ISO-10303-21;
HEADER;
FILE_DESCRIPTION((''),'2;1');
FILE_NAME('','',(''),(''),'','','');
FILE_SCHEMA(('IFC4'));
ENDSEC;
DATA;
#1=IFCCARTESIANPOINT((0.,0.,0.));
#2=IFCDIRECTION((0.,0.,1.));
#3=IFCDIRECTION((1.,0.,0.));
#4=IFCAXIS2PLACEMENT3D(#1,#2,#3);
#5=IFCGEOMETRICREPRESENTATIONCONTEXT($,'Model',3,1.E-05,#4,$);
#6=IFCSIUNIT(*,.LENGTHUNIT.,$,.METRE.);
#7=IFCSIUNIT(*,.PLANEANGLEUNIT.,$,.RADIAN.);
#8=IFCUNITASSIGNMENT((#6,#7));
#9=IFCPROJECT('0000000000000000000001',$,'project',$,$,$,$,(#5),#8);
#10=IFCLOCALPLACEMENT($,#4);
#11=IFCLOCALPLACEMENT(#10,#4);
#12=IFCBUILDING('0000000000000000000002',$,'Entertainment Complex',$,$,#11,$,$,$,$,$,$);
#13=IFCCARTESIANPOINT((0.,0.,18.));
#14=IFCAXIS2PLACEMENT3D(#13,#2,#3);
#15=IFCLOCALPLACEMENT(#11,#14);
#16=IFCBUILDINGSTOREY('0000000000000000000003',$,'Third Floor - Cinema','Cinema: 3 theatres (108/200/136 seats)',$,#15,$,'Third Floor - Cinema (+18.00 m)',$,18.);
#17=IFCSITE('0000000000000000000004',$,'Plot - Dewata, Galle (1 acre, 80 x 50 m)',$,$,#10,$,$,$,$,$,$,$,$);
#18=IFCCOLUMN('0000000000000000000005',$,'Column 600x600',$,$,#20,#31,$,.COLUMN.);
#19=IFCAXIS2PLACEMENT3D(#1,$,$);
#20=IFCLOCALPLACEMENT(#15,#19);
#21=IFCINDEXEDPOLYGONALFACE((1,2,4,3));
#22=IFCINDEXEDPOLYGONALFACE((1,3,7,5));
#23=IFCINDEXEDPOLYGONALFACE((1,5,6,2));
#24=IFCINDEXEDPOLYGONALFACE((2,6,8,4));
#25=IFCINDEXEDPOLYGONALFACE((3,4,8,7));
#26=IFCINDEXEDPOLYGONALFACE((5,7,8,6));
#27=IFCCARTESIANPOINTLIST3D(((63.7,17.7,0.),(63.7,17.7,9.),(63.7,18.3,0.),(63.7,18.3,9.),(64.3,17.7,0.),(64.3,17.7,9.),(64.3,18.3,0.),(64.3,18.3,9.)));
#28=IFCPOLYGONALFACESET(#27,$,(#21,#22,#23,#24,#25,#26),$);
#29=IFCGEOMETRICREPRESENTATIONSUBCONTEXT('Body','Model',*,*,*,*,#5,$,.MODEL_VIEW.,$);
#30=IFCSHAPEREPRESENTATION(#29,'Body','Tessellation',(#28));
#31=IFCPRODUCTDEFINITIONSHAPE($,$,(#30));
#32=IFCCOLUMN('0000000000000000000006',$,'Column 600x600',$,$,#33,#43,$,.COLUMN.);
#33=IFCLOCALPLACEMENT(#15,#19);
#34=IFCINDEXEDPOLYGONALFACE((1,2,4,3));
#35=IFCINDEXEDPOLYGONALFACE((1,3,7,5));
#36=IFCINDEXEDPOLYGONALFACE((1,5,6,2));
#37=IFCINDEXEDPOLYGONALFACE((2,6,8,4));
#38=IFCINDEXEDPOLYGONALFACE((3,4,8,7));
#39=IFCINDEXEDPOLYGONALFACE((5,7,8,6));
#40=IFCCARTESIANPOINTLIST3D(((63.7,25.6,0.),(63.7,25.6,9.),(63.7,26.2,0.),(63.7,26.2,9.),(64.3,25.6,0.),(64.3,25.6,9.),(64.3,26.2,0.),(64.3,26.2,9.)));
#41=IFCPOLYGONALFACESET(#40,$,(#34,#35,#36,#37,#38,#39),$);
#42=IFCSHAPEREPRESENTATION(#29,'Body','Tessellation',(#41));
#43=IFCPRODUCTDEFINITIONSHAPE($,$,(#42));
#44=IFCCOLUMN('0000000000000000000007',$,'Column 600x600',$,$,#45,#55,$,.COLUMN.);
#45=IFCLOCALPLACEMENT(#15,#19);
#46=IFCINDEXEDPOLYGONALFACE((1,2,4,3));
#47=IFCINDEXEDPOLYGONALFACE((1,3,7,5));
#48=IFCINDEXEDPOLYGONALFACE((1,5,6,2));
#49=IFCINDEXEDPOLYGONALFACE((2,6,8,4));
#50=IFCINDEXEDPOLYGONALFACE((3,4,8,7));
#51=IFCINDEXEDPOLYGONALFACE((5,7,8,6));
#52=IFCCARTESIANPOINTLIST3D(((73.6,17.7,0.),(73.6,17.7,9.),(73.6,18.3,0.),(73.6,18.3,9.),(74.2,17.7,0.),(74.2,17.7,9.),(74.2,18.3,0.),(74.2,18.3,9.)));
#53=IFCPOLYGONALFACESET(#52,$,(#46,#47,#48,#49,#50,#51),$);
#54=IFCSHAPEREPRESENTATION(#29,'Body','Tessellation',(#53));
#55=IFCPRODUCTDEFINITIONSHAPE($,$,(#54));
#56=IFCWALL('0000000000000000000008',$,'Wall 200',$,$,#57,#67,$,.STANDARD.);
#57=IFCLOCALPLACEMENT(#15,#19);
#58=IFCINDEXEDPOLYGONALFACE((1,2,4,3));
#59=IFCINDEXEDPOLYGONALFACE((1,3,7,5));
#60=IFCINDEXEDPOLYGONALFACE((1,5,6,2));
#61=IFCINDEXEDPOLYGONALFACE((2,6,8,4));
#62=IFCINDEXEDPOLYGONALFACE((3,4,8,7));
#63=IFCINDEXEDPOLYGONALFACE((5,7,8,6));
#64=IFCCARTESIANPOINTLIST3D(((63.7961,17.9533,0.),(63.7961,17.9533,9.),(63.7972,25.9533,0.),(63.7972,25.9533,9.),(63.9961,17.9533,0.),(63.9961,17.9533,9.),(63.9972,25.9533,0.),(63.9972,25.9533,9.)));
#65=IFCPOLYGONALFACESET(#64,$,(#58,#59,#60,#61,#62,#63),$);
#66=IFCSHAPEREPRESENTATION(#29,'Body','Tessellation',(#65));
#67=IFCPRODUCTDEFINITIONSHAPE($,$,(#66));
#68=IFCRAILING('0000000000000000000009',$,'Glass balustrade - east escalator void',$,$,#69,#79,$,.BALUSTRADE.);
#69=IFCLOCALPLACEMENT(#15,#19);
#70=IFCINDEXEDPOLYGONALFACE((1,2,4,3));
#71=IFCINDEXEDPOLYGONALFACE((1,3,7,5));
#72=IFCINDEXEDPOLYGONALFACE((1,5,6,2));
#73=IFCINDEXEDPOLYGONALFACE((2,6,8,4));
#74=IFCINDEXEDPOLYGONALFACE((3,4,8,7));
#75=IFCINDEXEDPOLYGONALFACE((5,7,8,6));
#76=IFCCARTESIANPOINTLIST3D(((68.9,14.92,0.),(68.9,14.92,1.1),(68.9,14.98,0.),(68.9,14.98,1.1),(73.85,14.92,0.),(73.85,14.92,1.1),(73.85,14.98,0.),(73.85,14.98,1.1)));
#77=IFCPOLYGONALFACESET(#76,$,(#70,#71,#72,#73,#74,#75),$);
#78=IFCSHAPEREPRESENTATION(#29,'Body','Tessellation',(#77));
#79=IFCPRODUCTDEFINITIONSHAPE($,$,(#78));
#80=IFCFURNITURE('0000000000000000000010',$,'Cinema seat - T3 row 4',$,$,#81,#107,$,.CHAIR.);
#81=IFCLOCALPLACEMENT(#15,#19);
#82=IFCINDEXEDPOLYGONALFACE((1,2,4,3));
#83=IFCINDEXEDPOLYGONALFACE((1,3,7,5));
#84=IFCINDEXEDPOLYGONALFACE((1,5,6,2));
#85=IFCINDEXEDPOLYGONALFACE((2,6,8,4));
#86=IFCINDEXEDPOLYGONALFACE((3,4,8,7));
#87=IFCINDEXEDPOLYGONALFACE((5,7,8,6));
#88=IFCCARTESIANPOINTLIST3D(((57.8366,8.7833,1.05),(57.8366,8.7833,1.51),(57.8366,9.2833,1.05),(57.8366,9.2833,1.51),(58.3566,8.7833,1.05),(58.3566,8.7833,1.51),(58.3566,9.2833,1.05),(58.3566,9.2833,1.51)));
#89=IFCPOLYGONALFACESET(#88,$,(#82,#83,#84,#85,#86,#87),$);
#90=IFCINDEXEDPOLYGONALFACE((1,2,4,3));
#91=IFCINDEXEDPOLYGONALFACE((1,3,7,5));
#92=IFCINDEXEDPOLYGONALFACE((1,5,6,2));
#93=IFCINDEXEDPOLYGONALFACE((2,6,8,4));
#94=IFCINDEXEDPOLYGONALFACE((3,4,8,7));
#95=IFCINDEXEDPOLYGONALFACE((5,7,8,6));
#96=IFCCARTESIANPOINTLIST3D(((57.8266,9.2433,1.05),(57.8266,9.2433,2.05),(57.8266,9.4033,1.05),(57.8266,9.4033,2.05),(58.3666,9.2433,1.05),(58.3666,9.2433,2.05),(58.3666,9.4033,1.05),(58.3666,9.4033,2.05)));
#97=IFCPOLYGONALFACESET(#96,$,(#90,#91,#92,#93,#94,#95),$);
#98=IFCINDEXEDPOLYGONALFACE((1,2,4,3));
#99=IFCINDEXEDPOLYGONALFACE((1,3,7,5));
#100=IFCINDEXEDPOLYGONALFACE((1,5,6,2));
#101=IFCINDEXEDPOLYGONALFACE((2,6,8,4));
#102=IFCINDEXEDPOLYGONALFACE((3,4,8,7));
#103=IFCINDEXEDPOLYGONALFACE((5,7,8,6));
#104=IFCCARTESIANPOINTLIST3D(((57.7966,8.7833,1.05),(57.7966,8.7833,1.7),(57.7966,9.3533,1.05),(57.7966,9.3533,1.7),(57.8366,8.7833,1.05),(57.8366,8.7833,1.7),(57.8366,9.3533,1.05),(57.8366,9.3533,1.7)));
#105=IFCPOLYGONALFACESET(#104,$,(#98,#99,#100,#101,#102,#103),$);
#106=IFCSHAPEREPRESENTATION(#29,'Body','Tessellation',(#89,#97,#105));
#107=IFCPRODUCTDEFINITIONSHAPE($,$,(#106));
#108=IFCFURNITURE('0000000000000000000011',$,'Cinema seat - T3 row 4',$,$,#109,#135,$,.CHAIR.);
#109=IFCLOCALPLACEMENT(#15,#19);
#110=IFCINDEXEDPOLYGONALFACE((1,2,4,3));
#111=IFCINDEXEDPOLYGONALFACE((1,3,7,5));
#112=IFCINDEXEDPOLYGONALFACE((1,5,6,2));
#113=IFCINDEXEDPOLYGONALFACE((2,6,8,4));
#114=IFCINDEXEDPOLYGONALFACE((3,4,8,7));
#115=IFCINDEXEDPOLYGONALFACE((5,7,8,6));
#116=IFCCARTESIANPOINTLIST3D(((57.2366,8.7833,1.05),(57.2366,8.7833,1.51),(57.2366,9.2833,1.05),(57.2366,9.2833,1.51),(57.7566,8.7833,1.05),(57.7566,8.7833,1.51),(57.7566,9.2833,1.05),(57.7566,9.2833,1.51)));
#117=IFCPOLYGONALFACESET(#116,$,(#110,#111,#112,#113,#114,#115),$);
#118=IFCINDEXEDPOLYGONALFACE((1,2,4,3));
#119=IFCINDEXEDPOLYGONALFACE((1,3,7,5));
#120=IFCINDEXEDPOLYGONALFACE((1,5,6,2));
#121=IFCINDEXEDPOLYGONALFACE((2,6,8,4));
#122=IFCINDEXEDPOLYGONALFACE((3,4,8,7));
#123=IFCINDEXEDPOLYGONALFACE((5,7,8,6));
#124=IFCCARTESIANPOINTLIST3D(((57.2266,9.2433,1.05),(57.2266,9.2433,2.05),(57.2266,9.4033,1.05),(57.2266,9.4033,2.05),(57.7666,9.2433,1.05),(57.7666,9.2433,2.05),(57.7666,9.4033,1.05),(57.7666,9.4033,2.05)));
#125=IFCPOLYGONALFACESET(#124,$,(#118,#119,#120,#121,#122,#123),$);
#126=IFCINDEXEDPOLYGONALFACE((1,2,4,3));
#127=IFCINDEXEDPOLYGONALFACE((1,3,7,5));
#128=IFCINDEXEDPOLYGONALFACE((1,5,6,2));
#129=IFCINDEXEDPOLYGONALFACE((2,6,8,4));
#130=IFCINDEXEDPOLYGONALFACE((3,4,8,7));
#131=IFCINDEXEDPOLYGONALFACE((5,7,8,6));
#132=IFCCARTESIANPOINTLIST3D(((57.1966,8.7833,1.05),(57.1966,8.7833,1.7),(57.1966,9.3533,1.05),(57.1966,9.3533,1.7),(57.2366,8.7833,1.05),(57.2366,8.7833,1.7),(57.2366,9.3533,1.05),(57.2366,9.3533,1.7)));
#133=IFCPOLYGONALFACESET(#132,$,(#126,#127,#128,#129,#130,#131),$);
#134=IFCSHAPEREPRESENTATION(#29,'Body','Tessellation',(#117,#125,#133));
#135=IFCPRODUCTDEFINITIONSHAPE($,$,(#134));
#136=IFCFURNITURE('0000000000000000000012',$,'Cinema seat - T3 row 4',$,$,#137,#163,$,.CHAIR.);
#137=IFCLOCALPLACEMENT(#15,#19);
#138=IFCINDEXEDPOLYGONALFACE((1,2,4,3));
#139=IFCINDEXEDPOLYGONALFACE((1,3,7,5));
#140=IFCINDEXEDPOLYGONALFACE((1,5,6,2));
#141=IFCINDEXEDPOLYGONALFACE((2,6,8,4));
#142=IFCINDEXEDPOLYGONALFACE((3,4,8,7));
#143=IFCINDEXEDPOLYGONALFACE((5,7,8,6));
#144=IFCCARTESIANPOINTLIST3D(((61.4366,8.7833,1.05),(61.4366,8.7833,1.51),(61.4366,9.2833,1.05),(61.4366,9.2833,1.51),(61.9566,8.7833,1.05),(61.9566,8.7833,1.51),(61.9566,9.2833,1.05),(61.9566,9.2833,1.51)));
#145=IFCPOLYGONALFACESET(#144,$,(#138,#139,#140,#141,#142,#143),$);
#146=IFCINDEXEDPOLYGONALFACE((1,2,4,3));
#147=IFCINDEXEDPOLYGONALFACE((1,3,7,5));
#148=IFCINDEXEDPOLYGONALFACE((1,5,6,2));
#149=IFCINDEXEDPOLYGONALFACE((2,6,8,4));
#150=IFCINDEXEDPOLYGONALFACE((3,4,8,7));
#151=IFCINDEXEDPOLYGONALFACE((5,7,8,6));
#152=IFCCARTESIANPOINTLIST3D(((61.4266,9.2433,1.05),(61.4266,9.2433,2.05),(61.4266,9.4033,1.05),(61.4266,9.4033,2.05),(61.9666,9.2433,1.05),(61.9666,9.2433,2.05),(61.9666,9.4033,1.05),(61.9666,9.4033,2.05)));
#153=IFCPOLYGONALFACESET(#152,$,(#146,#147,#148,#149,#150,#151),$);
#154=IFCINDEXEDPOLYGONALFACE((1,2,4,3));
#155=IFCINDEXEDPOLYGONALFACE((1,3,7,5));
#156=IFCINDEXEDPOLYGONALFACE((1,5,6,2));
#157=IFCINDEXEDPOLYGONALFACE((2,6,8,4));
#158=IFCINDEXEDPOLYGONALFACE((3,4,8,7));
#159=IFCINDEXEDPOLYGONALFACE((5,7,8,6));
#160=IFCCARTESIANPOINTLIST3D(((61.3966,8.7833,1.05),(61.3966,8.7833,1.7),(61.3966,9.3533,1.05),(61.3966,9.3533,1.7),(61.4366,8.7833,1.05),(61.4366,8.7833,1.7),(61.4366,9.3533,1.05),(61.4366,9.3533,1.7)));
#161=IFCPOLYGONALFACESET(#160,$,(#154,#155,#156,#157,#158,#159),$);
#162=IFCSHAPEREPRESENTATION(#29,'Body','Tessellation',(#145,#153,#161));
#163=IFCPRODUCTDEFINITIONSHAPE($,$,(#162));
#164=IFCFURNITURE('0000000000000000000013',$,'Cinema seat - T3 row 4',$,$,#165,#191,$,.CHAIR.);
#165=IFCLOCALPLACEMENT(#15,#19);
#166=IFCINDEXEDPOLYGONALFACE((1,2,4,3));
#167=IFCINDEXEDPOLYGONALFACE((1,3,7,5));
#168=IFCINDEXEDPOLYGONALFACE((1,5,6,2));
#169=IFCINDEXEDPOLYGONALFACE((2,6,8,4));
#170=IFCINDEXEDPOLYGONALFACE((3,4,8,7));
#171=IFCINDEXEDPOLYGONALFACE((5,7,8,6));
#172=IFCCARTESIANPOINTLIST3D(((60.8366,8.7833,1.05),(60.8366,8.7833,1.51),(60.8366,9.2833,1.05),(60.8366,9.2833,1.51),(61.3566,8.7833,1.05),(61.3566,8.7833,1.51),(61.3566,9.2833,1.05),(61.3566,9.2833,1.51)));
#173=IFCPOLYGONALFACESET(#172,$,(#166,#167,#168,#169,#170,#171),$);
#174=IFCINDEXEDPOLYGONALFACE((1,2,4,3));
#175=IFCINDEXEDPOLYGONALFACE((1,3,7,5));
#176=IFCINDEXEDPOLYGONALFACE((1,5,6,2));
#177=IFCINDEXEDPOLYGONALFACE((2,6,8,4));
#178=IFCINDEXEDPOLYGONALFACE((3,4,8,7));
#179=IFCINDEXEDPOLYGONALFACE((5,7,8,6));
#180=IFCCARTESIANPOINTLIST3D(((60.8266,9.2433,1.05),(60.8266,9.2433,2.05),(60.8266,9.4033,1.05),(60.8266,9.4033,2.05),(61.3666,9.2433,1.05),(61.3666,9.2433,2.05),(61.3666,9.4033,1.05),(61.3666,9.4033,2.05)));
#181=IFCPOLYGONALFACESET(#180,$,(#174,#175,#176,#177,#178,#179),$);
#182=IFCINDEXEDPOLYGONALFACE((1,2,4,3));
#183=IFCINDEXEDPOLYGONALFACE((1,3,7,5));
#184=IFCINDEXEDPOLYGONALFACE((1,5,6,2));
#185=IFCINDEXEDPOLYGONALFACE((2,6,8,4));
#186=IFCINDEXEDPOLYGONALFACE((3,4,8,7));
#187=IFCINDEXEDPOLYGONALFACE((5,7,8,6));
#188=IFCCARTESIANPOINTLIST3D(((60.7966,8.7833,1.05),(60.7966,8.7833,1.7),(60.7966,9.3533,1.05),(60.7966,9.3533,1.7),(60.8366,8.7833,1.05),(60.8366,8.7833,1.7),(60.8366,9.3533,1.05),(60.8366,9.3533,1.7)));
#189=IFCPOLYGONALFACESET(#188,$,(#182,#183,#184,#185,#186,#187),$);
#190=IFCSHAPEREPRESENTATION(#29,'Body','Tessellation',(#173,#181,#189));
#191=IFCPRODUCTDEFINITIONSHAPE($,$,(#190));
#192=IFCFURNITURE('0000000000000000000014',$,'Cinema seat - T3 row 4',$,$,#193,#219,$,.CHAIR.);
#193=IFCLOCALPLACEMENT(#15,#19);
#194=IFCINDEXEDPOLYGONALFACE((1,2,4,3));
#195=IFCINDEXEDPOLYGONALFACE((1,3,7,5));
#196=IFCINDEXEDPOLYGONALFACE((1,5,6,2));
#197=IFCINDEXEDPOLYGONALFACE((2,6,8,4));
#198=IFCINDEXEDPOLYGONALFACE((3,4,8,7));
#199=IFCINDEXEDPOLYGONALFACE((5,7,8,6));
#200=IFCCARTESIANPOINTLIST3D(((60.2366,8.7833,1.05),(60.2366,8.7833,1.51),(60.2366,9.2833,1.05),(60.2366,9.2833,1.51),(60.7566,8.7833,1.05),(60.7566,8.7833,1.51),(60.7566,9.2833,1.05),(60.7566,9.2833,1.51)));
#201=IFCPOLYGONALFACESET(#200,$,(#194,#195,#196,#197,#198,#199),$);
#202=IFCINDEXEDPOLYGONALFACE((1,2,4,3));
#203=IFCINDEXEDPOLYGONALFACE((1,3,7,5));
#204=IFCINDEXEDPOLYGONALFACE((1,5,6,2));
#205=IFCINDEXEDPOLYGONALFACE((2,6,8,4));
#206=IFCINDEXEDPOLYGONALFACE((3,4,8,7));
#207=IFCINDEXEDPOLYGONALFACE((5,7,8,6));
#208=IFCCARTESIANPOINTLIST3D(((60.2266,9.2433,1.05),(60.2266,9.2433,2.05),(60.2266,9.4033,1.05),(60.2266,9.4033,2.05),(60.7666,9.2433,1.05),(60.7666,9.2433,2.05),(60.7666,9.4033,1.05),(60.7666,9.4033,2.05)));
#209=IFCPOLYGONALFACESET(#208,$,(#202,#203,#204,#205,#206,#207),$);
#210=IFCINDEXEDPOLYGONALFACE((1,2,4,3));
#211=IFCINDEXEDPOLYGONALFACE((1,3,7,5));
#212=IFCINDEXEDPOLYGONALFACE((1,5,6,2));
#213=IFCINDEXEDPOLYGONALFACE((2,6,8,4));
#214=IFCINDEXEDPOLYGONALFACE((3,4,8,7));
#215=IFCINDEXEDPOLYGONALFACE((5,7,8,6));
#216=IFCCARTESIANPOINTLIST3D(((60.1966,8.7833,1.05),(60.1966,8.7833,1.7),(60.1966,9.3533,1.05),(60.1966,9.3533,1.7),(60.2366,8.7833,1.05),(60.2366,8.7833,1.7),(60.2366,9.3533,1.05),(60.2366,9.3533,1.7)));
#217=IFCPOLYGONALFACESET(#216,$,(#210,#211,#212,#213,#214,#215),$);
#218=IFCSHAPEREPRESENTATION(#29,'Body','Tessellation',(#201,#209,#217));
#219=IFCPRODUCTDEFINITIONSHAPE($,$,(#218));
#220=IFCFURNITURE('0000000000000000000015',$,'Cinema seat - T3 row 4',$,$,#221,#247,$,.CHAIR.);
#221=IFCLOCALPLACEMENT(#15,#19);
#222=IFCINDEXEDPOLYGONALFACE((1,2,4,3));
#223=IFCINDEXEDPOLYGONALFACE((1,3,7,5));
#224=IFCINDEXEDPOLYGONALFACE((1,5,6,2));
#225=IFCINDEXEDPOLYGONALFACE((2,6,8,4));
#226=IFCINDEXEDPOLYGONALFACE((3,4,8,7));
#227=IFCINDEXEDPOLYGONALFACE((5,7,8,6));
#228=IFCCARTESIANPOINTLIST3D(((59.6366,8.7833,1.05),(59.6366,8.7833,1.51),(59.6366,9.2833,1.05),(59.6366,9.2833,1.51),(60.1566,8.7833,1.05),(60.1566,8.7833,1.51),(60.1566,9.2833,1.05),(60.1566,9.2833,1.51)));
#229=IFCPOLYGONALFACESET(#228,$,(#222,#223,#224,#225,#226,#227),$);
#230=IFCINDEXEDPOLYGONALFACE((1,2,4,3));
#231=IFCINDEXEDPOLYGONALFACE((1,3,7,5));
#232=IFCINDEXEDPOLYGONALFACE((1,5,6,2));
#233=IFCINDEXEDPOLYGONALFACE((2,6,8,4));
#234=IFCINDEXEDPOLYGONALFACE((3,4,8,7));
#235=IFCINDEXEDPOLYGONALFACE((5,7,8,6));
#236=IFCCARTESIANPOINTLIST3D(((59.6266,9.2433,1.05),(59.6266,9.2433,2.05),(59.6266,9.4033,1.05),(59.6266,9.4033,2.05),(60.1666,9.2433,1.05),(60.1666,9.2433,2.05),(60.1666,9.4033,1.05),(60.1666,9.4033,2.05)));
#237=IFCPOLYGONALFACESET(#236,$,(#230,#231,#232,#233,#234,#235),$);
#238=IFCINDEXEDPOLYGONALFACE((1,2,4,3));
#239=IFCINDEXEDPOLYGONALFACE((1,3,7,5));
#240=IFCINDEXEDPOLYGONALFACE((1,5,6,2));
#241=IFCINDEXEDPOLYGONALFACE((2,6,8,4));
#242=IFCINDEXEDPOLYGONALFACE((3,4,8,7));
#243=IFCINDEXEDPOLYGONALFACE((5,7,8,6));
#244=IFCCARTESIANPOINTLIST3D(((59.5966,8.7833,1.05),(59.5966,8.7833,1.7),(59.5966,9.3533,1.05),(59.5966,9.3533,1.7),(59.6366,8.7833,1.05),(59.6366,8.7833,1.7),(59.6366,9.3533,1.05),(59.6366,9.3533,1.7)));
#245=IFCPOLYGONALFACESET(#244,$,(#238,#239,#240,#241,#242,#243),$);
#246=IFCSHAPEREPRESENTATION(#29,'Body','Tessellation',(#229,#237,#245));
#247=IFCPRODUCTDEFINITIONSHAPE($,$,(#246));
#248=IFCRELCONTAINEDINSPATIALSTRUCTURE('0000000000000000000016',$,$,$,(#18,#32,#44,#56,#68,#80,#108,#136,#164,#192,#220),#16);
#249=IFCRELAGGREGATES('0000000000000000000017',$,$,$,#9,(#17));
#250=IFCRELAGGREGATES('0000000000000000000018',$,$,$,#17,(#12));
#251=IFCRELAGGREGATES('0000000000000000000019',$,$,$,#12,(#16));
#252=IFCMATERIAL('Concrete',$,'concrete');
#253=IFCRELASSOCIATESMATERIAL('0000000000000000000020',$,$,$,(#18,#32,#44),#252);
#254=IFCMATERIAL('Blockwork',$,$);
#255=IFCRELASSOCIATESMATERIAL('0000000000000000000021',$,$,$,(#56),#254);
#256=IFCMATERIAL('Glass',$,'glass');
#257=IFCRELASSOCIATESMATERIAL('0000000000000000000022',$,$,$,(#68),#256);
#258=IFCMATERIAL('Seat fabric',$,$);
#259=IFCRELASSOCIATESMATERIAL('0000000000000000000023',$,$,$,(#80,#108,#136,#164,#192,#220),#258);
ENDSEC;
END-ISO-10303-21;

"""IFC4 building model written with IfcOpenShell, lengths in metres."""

from ifc_helpers import new_model, si_unit, frame, origin_with_axes, place, context, subcontext, project, spatial, polyline, outline, extrude, material, element, save


model = new_model("IFC4")

# Units and contexts
model_context = context("Model", 3, precision=1e-05, world=origin_with_axes())
body_context = subcontext(model_context, "Body", "Model", "MODEL_VIEW")
ifc_project = project(units=[si_unit("LENGTHUNIT", "METRE"), si_unit("PLANEANGLEUNIT", "RADIAN")], contexts=[model_context])

# Site, building, storey
site_placement = place(None, origin_with_axes())
site = spatial("IfcSite", under=ifc_project, at=site_placement, Name="Plot - Dewata, Galle (1 acre, 80 x 50 m)")
building_placement = place(site_placement, origin_with_axes())
building = spatial("IfcBuilding", under=site, at=building_placement, Name="Entertainment Complex")
storey_placement = place(building_placement, frame((0.0, 0.0, 18.0), z_axis=(0.0, 0.0, 1.0), x_axis=(1.0, 0.0, 0.0)))
storey = spatial("IfcBuildingStorey", under=building, at=storey_placement, Name="Third Floor - Cinema", Description="Cinema: 3 theatres (108/200/136 seats)", LongName="Third Floor - Cinema (+18.00 m)", Elevation=18.0)

# Columns
ifc_material_1 = material(Name="Concrete", Category="concrete")
for number, where, z_axis, x_axis, name in (
    (1, (64.0, 18.0, 0.0), (0.0, 0.0, 1.0), (1.0, 0.0, 0.0), "Column 600x600"),
    (2, (64.0, 25.9, 0.0), (0.0, 0.0, 1.0), (1.0, 0.0, 0.0), "Column 600x600"),
    (3, (73.9, 18.0, 0.0), (0.0, 0.0, 1.0), (1.0, 0.0, 0.0), "Column 600x600"),
):
    element("IfcColumn", number, at=place(storey_placement, frame(where, z_axis=z_axis, x_axis=x_axis)), inside=storey, material=ifc_material_1, Name=name, PredefinedType="COLUMN", context=body_context, shape_type="SweptSolid", body=[
        extrude(outline(polyline([(-0.3, -0.3), (0.3, -0.3), (0.3, 0.3), (-0.3, 0.3), (-0.3, -0.3)])), origin_with_axes(), (0.0, 0.0, 1.0), 9.0),
    ])

# Wall
ifc_material_2 = material(Name="Blockwork")
wall_placement = place(storey_placement, frame((63.8961, 17.9533, 0.0), z_axis=(0.0, 0.0, 1.0), x_axis=(0.000137, 1.0, 0.0)))
element("IfcWall", 4, at=wall_placement, inside=storey, material=ifc_material_2, Name="Wall 200", PredefinedType="STANDARD", context=body_context, shape_type="SweptSolid", body=[
    extrude(outline(polyline([(0.0, -0.1), (8.0, -0.1), (8.0, 0.1), (0.0, 0.1), (0.0, -0.1)])), origin_with_axes(), (0.0, 0.0, 1.0), 9.0),
])

# Railing
ifc_material_3 = material(Name="Glass", Category="glass")
railing_placement = place(storey_placement, frame((68.9, 14.95, 0.0), z_axis=(0.0, 0.0, 1.0), x_axis=(1.0, 0.0, 0.0)))
element("IfcRailing", 5, at=railing_placement, inside=storey, material=ifc_material_3, Name="Glass balustrade - east escalator void", PredefinedType="BALUSTRADE", context=body_context, shape_type="SweptSolid", body=[
    extrude(outline(polyline([(0.0, -0.03), (4.95, -0.03), (4.95, 0.03), (0.0, 0.03), (0.0, -0.03)])), origin_with_axes(), (0.0, 0.0, 1.0), 1.1),
])

# Furniture
ifc_material_4 = material(Name="Seat fabric")
for number, where, z_axis, x_axis, name in (
    (6, (58.0966, 9.4033, 1.05), (0.0, 0.0, 1.0), (0.0, 1.0, 0.0), "Cinema seat - T3 row 4"),
    (7, (57.4966, 9.4033, 1.05), (0.0, 0.0, 1.0), (0.0, 1.0, 0.0), "Cinema seat - T3 row 4"),
    (8, (61.6966, 9.4033, 1.05), (0.0, 0.0, 1.0), (0.0, 1.0, 0.0), "Cinema seat - T3 row 4"),
    (9, (61.0966, 9.4033, 1.05), (0.0, 0.0, 1.0), (0.0, 1.0, 0.0), "Cinema seat - T3 row 4"),
    (10, (60.4966, 9.4033, 1.05), (0.0, 0.0, 1.0), (0.0, 1.0, 0.0), "Cinema seat - T3 row 4"),
    (11, (59.8966, 9.4033, 1.05), (0.0, 0.0, 1.0), (0.0, 1.0, 0.0), "Cinema seat - T3 row 4"),
):
    element("IfcFurniture", number, at=place(storey_placement, frame(where, z_axis=z_axis, x_axis=x_axis)), inside=storey, material=ifc_material_4, Name=name, PredefinedType="CHAIR", context=body_context, shape_type="SweptSolid", body=[
        extrude(outline(polyline([(-0.62, -0.26), (-0.12, -0.26), (-0.12, 0.26), (-0.62, 0.26), (-0.62, -0.26)])), origin_with_axes(), (0.0, 0.0, 1.0), 0.46),
        extrude(outline(polyline([(-0.16, -0.27), (0.0, -0.27), (0.0, 0.27), (-0.16, 0.27), (-0.16, -0.27)])), origin_with_axes(), (0.0, 0.0, 1.0), 1.0),
        extrude(outline(polyline([(-0.62, 0.26), (-0.05, 0.26), (-0.05, 0.3), (-0.62, 0.3), (-0.62, 0.26)])), origin_with_axes(), (0.0, 0.0, 1.0), 0.65),
    ])

save(model, "model.ifc")
